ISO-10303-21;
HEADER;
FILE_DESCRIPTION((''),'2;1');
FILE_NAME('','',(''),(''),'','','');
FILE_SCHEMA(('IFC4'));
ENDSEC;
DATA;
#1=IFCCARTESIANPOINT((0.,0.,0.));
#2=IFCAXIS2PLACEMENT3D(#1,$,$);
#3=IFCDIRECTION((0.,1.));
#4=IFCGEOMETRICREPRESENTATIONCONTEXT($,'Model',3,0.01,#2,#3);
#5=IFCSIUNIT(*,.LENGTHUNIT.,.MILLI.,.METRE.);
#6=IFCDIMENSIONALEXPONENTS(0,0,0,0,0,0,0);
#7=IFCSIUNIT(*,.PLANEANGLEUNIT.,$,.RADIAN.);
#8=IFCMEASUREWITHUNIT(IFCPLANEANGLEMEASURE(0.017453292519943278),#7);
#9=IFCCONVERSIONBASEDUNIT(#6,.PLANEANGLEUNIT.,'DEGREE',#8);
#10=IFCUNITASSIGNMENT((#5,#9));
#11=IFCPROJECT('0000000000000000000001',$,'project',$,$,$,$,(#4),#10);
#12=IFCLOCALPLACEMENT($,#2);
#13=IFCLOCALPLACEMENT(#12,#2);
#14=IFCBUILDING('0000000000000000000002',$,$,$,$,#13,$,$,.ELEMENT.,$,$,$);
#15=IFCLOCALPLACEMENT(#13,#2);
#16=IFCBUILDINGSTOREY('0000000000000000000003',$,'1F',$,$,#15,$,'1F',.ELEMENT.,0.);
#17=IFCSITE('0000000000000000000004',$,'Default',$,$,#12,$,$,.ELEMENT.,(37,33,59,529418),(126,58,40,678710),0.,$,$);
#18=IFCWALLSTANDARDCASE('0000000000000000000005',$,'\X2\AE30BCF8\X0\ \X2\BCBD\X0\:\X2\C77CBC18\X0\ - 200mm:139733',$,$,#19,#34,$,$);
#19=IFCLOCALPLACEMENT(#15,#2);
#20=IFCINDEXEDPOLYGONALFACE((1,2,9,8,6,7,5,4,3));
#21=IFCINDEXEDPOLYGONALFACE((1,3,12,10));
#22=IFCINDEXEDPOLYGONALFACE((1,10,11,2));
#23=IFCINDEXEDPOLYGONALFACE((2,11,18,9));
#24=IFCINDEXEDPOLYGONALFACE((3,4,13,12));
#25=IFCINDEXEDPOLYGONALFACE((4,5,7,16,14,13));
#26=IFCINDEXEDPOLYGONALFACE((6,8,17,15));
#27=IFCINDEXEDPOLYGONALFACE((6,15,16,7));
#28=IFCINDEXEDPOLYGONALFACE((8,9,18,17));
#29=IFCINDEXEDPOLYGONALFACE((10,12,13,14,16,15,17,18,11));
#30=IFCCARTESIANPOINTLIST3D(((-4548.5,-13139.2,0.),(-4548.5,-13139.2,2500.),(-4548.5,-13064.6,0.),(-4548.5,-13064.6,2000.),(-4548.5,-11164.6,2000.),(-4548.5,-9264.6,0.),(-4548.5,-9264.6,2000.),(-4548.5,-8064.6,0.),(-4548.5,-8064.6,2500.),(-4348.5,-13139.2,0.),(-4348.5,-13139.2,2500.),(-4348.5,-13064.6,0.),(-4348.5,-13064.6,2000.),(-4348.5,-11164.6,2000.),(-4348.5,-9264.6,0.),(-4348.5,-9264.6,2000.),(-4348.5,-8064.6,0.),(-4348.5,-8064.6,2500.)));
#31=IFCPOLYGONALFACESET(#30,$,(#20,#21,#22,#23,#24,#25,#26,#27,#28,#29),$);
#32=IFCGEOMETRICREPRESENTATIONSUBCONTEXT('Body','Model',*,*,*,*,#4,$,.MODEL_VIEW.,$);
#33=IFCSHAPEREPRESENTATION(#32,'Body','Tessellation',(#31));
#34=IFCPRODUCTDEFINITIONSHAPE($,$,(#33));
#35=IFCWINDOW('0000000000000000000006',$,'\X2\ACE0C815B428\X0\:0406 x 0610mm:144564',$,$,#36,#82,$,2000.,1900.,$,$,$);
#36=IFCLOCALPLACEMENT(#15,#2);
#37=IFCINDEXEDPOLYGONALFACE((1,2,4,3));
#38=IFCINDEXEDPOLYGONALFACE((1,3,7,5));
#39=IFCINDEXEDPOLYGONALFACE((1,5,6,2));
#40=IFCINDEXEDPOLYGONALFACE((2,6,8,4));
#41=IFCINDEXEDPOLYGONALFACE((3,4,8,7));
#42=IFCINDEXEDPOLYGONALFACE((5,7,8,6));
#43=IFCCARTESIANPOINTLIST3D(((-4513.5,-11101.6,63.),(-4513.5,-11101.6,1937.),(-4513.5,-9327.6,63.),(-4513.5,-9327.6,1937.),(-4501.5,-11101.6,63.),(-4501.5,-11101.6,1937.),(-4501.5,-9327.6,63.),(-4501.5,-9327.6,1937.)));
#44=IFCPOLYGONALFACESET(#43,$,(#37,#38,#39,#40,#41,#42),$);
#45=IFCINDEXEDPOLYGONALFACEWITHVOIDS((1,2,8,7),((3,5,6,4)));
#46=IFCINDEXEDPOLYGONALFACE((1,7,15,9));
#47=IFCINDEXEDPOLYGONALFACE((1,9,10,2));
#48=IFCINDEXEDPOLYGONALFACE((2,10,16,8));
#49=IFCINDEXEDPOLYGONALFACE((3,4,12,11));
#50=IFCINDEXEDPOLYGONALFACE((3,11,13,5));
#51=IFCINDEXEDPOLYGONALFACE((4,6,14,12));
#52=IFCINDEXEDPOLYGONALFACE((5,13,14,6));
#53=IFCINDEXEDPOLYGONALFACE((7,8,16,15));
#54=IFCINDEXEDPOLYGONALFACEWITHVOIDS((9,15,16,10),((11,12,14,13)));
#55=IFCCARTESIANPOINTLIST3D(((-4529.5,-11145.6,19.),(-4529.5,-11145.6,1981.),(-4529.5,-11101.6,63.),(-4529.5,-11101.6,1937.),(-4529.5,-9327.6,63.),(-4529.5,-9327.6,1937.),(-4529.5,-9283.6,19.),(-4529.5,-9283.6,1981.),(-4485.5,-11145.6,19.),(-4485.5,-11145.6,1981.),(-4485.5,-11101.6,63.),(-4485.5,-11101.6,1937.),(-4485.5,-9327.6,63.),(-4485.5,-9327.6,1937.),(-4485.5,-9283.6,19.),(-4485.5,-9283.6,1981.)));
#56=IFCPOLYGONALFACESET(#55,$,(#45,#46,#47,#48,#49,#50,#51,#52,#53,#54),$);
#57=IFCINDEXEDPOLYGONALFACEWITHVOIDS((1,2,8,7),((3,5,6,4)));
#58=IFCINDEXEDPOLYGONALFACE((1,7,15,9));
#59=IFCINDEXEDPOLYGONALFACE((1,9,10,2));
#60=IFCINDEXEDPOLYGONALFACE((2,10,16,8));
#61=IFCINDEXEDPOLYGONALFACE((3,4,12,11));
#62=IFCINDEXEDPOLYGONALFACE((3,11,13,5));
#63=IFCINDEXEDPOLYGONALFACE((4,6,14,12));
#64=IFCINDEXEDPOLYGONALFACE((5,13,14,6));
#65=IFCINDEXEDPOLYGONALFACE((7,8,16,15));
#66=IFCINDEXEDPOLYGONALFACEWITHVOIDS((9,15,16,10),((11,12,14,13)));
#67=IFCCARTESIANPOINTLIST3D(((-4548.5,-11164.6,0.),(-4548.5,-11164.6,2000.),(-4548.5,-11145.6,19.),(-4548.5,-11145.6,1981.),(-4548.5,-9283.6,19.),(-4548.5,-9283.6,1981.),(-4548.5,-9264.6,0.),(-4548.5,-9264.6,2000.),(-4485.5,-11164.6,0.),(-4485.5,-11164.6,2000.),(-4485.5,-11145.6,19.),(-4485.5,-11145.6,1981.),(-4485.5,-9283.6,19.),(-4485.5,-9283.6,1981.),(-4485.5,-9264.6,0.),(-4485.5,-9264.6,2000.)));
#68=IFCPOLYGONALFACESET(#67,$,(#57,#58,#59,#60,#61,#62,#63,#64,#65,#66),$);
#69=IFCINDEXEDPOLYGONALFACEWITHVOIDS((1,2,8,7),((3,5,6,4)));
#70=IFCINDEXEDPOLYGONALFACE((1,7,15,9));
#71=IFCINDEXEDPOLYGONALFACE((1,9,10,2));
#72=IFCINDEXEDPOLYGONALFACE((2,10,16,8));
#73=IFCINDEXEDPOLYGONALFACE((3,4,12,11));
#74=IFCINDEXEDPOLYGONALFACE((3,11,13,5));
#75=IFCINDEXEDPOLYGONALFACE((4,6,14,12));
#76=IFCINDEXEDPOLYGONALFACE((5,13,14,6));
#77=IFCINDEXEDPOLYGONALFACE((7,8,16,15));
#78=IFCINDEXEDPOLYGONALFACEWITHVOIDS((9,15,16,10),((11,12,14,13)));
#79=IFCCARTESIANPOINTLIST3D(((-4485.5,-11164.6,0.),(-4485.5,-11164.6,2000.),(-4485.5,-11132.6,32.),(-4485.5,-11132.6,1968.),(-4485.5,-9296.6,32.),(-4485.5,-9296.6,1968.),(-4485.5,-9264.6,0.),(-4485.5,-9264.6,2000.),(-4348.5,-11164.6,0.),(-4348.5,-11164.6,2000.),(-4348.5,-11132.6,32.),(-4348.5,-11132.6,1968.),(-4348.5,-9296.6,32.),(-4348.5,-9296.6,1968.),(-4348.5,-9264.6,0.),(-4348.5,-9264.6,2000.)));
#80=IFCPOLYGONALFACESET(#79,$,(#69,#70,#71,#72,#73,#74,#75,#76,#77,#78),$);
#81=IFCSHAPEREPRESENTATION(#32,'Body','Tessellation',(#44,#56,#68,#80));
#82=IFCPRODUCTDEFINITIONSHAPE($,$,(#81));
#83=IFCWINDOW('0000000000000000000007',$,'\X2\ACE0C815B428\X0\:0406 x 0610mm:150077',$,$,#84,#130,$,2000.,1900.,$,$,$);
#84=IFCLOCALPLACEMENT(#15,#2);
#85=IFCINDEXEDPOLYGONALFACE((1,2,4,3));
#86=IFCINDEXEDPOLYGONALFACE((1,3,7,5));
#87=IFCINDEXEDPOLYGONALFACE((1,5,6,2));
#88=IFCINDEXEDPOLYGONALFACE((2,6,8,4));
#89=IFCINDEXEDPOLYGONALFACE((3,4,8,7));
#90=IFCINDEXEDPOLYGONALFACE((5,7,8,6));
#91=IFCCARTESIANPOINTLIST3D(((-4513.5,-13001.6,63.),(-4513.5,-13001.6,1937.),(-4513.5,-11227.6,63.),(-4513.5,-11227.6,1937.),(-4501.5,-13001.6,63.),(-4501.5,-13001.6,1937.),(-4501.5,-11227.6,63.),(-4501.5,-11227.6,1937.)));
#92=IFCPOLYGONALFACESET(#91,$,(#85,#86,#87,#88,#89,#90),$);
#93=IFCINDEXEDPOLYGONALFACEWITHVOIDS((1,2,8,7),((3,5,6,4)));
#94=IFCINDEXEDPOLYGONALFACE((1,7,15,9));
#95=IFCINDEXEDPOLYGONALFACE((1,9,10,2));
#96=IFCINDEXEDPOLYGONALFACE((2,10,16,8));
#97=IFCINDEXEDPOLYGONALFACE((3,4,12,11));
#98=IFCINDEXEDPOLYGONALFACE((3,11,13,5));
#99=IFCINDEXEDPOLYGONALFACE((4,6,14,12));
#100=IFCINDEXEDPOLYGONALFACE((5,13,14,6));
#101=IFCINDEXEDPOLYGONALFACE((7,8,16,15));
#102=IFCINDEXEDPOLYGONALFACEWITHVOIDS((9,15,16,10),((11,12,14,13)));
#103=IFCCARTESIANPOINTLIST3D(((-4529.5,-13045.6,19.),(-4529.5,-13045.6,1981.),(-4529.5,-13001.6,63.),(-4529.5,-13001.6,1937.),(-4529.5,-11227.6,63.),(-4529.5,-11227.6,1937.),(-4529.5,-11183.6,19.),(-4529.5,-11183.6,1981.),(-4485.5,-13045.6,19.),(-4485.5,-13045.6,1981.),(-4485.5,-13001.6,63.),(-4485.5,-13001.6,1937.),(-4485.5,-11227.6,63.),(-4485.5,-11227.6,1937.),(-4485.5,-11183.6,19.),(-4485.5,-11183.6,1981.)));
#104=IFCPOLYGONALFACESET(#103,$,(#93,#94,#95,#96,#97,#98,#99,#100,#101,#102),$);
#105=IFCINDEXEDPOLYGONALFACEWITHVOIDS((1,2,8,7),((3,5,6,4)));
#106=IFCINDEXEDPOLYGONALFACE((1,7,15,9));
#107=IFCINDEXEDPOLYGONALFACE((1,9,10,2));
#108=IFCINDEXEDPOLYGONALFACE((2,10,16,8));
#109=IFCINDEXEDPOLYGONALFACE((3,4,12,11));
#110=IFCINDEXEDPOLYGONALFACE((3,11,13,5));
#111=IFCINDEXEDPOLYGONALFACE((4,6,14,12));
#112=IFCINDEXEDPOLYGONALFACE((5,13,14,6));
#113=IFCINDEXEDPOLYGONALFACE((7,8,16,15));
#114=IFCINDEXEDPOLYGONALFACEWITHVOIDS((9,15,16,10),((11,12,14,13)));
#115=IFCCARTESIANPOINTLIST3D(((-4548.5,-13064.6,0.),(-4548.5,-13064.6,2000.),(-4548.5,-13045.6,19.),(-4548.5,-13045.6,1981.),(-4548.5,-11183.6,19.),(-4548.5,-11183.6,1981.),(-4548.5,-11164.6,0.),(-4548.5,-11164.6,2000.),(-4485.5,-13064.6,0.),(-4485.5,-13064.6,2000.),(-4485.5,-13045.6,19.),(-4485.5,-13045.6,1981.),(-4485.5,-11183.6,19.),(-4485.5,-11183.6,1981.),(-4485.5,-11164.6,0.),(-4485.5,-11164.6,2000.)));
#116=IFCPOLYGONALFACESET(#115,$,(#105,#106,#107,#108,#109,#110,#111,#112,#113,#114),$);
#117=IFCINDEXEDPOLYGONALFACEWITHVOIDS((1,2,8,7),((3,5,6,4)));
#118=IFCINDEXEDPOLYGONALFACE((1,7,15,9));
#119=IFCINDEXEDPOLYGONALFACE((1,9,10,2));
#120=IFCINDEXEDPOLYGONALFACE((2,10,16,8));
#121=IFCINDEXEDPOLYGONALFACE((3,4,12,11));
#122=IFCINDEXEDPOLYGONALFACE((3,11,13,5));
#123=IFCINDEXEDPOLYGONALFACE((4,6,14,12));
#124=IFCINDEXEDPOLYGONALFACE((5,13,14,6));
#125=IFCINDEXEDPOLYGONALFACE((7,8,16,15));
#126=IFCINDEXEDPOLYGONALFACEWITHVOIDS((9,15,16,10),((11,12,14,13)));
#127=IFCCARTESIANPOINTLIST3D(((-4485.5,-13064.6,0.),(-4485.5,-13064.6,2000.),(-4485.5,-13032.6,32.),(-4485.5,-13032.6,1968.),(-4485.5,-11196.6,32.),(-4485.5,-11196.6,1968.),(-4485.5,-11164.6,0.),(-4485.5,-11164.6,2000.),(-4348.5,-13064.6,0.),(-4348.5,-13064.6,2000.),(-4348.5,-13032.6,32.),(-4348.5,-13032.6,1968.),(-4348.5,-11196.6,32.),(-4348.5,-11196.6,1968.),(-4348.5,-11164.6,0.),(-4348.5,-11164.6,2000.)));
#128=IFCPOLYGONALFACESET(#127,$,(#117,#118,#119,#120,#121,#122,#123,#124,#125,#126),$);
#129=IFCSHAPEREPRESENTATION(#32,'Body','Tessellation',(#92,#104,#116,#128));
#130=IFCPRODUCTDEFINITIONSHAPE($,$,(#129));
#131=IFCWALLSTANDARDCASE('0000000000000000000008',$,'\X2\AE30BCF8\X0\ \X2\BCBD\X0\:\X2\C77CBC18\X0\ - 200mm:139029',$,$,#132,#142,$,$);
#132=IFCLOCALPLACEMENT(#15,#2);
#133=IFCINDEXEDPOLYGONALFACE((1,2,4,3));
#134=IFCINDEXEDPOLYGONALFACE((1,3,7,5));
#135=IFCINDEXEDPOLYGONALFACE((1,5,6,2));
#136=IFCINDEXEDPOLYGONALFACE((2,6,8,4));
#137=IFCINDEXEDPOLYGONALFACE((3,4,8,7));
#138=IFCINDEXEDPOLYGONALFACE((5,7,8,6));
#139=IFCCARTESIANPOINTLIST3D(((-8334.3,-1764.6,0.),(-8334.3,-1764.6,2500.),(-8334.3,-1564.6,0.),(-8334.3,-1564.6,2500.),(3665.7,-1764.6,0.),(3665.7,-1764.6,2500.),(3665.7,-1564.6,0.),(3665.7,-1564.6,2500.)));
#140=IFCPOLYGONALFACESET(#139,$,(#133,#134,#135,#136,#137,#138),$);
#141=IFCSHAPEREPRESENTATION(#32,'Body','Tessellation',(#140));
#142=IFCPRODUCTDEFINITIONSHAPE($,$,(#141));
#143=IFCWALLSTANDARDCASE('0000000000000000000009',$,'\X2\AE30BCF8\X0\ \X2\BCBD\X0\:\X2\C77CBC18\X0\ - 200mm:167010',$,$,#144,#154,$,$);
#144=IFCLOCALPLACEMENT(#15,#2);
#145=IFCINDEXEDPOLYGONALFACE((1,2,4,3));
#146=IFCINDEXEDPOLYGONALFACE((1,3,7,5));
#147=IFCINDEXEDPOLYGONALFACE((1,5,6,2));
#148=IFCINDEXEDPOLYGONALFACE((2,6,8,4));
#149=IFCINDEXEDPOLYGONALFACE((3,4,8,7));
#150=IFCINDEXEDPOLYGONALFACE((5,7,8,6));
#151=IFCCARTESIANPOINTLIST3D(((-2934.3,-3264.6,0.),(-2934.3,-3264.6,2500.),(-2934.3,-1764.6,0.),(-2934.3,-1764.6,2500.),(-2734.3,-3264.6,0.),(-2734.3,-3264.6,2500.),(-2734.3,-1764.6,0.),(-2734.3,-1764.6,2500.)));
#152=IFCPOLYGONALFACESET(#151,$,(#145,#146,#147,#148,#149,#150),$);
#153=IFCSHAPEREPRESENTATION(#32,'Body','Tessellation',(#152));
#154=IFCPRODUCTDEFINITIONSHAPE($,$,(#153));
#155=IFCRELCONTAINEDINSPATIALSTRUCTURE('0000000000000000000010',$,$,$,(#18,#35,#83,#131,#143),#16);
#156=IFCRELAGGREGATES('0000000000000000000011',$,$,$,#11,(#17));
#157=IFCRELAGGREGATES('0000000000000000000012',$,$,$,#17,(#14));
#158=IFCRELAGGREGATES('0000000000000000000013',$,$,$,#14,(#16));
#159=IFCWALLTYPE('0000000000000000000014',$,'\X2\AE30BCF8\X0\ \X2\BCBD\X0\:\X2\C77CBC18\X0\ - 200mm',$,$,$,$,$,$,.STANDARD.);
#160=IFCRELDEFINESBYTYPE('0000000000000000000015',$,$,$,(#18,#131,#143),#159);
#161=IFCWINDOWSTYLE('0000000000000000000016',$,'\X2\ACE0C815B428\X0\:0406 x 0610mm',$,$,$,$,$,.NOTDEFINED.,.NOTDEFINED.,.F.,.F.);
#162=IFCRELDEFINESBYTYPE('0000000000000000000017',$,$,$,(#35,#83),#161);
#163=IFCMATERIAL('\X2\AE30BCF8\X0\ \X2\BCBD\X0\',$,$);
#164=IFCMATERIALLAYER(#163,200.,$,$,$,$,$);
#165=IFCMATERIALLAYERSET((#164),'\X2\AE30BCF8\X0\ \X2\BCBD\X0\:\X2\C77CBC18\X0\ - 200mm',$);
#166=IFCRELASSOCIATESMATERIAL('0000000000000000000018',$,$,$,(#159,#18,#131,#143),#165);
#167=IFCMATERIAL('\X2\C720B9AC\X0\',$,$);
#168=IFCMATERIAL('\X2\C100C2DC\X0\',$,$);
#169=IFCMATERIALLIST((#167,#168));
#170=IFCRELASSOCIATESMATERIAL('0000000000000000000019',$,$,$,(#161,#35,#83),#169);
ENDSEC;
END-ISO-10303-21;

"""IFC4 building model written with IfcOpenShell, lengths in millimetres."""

from ifc_helpers import new_model, entity, si_unit, converted_unit, direction, frame, frame_2d, origin, place, context, subcontext, project, spatial, polyline, rectangle, outline, extrude, source, transform, mapped, material, material_list, layer, layer_set, layer_usage, type_object, type_shapes, element, fill, save


model = new_model("IFC4")

# Units and contexts
model_context = context("Model", 3, precision=0.01, world=origin(), true_north=direction((0.0, 1.0)))
body_context = subcontext(model_context, "Body", "Model", "MODEL_VIEW")
ifc_project = project(units=[si_unit("LENGTHUNIT", "METRE", prefix="MILLI"), converted_unit("PLANEANGLEUNIT", "DEGREE", entity("IfcPlaneAngleMeasure", 0.017453292519943278), si_unit("PLANEANGLEUNIT", "RADIAN"), dimensions=[0, 0, 0, 0, 0, 0, 0])], contexts=[model_context])

# Site, building, storey
site_placement = place(None, origin())
site = spatial("IfcSite", under=ifc_project, at=site_placement, Name="Default", CompositionType="ELEMENT", RefLatitude=(37, 33, 59, 529418), RefLongitude=(126, 58, 40, 678710), RefElevation=0.0)
building_placement = place(site_placement, origin())
building = spatial("IfcBuilding", under=site, at=building_placement, CompositionType="ELEMENT")
storey_placement = place(building_placement, origin())
storey = spatial("IfcBuildingStorey", under=building, at=storey_placement, Name="1F", LongName="1F", CompositionType="ELEMENT", Elevation=0.0)

# Wall, openings, windows
ifc_material_1 = material(Name="기본 벽")
ifc_layer_1 = layer(ifc_material_1, 200.0)
ifc_layer_set_1 = layer_set([ifc_layer_1], Name="기본 벽:일반 - 200mm")
ifc_layer_usage_1 = layer_usage(ifc_layer_set_1, "AXIS2", "NEGATIVE", 100.0)
wall_type = type_object("IfcWallType", Name="기본 벽:일반 - 200mm", PredefinedType="STANDARD", material=ifc_layer_set_1)
wall_1_placement = place(storey_placement, frame((-4448.5, -13139.2, 0.0), z_axis=(0.0, 0.0, 1.0), x_axis=(0.0, 1.0, 0.0)))
wall_1 = element("IfcWallStandardCase", 1, at=wall_1_placement, inside=storey, type_object=wall_type, material=ifc_layer_usage_1, Name="기본 벽:일반 - 200mm:139733", context=body_context, shape_type="SweptSolid", body=[
    extrude(rectangle(XDim=5074.5, YDim=200.0, at=frame_2d((2537.3, 0.0), x_axis=(-1.0, 0.0))), origin(), (0.0, 0.0, 1.0), 2500.0),
])
opening_1_placement = place(wall_1_placement, frame((1974.5, -100.0, 0.0)))
opening_1 = element("IfcOpeningElement", 2, at=opening_1_placement, cuts=wall_1, ObjectType="Opening", context=body_context, shape_type="SweptSolid", body=[
    extrude(rectangle(XDim=2000.0, YDim=1900.0, at=frame_2d((1000.0, 950.0), x_axis=(1.0, 0.0))), frame((0.0, 0.0, 0.0), z_axis=(0.0, 1.0, 0.0), x_axis=(0.0, 0.0, 1.0)), (0.0, 0.0, 1.0), 200.0),
])
opening_2_placement = place(wall_1_placement, frame((74.5, -100.0, 0.0)))
opening_2 = element("IfcOpeningElement", 3, at=opening_2_placement, cuts=wall_1, ObjectType="Opening", context=body_context, shape_type="SweptSolid", body=[
    extrude(rectangle(XDim=2000.0, YDim=1900.0, at=frame_2d((1000.0, 950.0), x_axis=(1.0, 0.0))), frame((0.0, 0.0, 0.0), z_axis=(0.0, 1.0, 0.0), x_axis=(0.0, 0.0, 1.0)), (0.0, 0.0, 1.0), 200.0),
])
ifc_material_2 = material(Name="유리")
ifc_material_3 = material(Name="섀시")
ifc_material_list = material_list([ifc_material_2, ifc_material_3])
window_style = type_object("IfcWindowStyle", Name="고정됨:0406 x 0610mm", ConstructionType="NOTDEFINED", OperationType="NOTDEFINED", ParameterTakesPrecedence=False, Sizeable=False, material=ifc_material_list)
shared_shape = source(origin(), body_context, "Body", "SweptSolid", [
    extrude(rectangle(XDim=12.0, YDim=1774.0, at=frame_2d((0.0, 0.0), x_axis=(1.0, 0.0))), frame((950.0, 159.0, 63.0), z_axis=(0.0, 0.0, 1.0), x_axis=(0.0, -1.0, 0.0)), (0.0, 0.0, 1.0), 1874.0),
    extrude(outline(polyline([(-931.0, -981.0), (931.0, -981.0), (931.0, 981.0), (-931.0, 981.0), (-931.0, -981.0)]), holes=[polyline([(-887.0, -937.0), (-887.0, 937.0), (887.0, 937.0), (887.0, -937.0), (-887.0, -937.0)])]), frame((950.0, 137.0, 1000.0), z_axis=(0.0, 1.0, 0.0), x_axis=(1.0, 0.0, 0.0)), (0.0, 0.0, 1.0), 44.0),
    extrude(outline(polyline([(-950.0, -1000.0), (950.0, -1000.0), (950.0, 1000.0), (-950.0, 1000.0), (-950.0, -1000.0)]), holes=[polyline([(-931.0, -981.0), (-931.0, 981.0), (931.0, 981.0), (931.0, -981.0), (-931.0, -981.0)])]), frame((950.0, 137.0, 1000.0), z_axis=(0.0, 1.0, 0.0), x_axis=(1.0, 0.0, 0.0)), (0.0, 0.0, 1.0), 63.0),
    extrude(outline(polyline([(-950.0, -1000.0), (950.0, -1000.0), (950.0, 1000.0), (-950.0, 1000.0), (-950.0, -1000.0)]), holes=[polyline([(-918.0, -968.0), (-918.0, 968.0), (918.0, 968.0), (918.0, -968.0), (-918.0, -968.0)])]), frame((950.0, 0.0, 1000.0), z_axis=(0.0, 1.0, 0.0), x_axis=(1.0, 0.0, 0.0)), (0.0, 0.0, 1.0), 137.0),
])
type_shapes(window_style, [shared_shape])
window_1_placement = place(opening_1_placement, origin())
window_1 = element("IfcWindow", 4, at=window_1_placement, inside=storey, type_object=window_style, material=ifc_material_list, Name="고정됨:0406 x 0610mm:144564", OverallHeight=2000.0, OverallWidth=1900.0, context=body_context, shape_type="MappedRepresentation", body=[
    mapped(shared_shape, transform((0.0, 0.0, 0.0), scale=1.0)),
])
fill(opening_1, window_1)
window_2_placement = place(opening_2_placement, origin())
window_2 = element("IfcWindow", 5, at=window_2_placement, inside=storey, type_object=window_style, material=ifc_material_list, Name="고정됨:0406 x 0610mm:150077", OverallHeight=2000.0, OverallWidth=1900.0, context=body_context, shape_type="MappedRepresentation", body=[
    mapped(shared_shape, transform((0.0, 0.0, 0.0), scale=1.0)),
])
fill(opening_2, window_2)

# Walls
ifc_layer_usage_2 = layer_usage(ifc_layer_set_1, "AXIS2", "NEGATIVE", 100.0)
wall_2_placement = place(storey_placement, frame((-8334.3, -1664.6, 0.0)))
element("IfcWallStandardCase", 6, at=wall_2_placement, inside=storey, type_object=wall_type, material=ifc_layer_usage_2, Name="기본 벽:일반 - 200mm:139029", context=body_context, shape_type="SweptSolid", body=[
    extrude(rectangle(XDim=12000.0, YDim=200.0, at=frame_2d((6000.0, 0.0), x_axis=(-1.0, 0.0))), origin(), (0.0, 0.0, 1.0), 2500.0),
])
ifc_layer_usage_3 = layer_usage(ifc_layer_set_1, "AXIS2", "NEGATIVE", 100.0)
wall_3_placement = place(storey_placement, frame((-2834.3, -1764.6, 0.0), z_axis=(0.0, 0.0, 1.0), x_axis=(0.0, -1.0, 0.0)))
element("IfcWallStandardCase", 7, at=wall_3_placement, inside=storey, type_object=wall_type, material=ifc_layer_usage_3, Name="기본 벽:일반 - 200mm:167010", context=body_context, shape_type="SweptSolid", body=[
    extrude(rectangle(XDim=1500.0, YDim=200.0, at=frame_2d((750.0, 0.0), x_axis=(-1.0, 0.0))), origin(), (0.0, 0.0, 1.0), 2500.0),
])

save(model, "model.ifc")
